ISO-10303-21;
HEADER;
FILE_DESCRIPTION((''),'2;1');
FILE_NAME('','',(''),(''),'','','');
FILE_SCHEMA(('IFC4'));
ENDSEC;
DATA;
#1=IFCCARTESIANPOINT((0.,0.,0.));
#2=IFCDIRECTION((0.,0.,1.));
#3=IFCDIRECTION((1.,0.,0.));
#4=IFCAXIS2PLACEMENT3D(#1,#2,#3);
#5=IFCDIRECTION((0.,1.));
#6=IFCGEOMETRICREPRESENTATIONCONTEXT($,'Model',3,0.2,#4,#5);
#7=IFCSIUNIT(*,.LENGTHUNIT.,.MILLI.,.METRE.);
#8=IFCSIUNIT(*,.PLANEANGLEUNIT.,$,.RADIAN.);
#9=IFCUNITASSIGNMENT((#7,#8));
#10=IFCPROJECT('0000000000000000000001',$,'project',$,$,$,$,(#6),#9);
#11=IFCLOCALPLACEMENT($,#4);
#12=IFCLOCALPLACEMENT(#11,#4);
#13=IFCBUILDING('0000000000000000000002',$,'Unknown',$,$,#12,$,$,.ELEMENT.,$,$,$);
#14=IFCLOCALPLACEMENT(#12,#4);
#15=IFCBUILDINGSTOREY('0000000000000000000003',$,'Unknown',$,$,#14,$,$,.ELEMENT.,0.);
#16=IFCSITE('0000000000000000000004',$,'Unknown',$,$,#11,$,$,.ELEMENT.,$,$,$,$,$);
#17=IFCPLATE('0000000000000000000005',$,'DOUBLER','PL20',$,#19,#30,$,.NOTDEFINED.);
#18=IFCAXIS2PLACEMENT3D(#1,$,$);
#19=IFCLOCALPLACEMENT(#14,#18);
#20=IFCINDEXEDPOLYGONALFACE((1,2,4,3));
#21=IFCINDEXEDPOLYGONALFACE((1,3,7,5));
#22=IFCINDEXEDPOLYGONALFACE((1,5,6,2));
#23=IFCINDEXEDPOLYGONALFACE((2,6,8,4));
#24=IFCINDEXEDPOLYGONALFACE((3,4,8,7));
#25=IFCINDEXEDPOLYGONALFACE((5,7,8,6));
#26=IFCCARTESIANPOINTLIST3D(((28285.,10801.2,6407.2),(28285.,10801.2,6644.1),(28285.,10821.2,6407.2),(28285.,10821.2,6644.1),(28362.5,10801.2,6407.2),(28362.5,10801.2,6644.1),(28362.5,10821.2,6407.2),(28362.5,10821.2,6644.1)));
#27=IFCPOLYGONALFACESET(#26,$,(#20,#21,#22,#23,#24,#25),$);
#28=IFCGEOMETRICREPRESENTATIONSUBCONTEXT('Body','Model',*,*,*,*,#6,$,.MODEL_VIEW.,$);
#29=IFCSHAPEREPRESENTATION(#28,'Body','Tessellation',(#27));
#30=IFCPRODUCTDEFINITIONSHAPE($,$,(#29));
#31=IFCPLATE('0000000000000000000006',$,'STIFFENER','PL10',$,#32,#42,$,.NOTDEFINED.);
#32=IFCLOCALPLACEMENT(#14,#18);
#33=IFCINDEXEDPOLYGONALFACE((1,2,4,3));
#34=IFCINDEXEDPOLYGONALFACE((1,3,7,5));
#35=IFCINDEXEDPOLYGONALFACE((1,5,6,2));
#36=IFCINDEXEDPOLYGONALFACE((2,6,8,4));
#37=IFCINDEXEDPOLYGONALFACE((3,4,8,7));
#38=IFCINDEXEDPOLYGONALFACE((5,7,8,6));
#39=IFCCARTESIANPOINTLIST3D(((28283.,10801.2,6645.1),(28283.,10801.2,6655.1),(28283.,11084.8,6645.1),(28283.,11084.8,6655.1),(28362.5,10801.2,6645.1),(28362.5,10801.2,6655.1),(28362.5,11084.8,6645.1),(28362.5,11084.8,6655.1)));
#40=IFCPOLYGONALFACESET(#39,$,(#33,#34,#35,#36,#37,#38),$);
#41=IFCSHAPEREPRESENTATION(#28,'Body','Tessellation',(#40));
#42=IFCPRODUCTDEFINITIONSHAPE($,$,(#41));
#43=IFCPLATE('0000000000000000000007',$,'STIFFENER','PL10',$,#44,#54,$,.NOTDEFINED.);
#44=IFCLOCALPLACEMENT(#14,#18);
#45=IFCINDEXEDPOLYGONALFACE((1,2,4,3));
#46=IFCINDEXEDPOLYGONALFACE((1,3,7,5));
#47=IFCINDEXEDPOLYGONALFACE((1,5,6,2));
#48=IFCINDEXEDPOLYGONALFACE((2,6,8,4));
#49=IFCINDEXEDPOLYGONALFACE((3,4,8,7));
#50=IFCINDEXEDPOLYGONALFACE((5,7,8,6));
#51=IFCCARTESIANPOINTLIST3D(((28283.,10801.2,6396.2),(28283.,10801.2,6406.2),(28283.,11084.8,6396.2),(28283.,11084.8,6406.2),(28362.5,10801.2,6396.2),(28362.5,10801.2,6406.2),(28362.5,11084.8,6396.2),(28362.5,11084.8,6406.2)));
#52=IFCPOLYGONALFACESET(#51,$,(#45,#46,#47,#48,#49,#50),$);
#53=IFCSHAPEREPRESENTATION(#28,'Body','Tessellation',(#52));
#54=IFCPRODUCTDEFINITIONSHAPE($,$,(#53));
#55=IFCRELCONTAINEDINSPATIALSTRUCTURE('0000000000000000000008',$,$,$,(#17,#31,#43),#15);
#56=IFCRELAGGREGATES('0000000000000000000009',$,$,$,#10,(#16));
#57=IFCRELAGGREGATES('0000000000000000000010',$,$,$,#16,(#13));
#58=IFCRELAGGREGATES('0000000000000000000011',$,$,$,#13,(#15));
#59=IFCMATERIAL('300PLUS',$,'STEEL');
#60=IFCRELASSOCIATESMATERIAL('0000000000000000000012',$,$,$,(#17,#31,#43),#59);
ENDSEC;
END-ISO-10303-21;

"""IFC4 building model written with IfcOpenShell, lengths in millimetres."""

from ifc_helpers import new_model, si_unit, direction, frame, origin_with_axes, place, context, subcontext, project, spatial, line, indexed_curve, outline, extrude, material, element, save


model = new_model("IFC4")

# Units and contexts
model_context = context("Model", 3, precision=0.2, world=origin_with_axes(), true_north=direction((0.0, 1.0)))
body_context = subcontext(model_context, "Body", "Model", "MODEL_VIEW")
ifc_project = project(units=[si_unit("LENGTHUNIT", "METRE", prefix="MILLI"), si_unit("PLANEANGLEUNIT", "RADIAN")], contexts=[model_context])

# Site, building, storey
site_placement = place(None, origin_with_axes())
site = spatial("IfcSite", under=ifc_project, at=site_placement, Name="Unknown", CompositionType="ELEMENT")
building_placement = place(site_placement, origin_with_axes())
building = spatial("IfcBuilding", under=site, at=building_placement, Name="Unknown", CompositionType="ELEMENT")
storey_placement = place(building_placement, origin_with_axes())
storey = spatial("IfcBuildingStorey", under=building, at=storey_placement, Name="Unknown", CompositionType="ELEMENT", Elevation=0.0)

# Shared definitions
ifc_material_1 = material(Name="300PLUS", Category="STEEL")

# Plates
plate_1_placement = place(storey_placement, frame((28285.0, 10811.2, 6407.2), z_axis=(0.0, -1.0, 0.0), x_axis=(1.0, 0.0, 0.0)))
element("IfcPlate", 1, at=plate_1_placement, inside=storey, material=ifc_material_1, Name="DOUBLER", Description="PL20", PredefinedType="NOTDEFINED", context=body_context, shape_type="SolidModel", body=[
    extrude(outline(indexed_curve([(0.0, 0.0), (77.5, 0.0), (77.5, 236.9), (0.0, 236.9)], segments=[line(1, 2, 3, 4, 1)])), frame((0.0, 0.0, 10.0), z_axis=(0.0, 0.0, 1.0), x_axis=(1.0, 0.0, 0.0)), (0.0, 0.0, -1.0), 20.0),
])
for number, where, z_axis, x_axis, name in (
    (2, (28283.0, 10801.2, 6650.1), (0.0, 0.0, 1.0), (1.0, 0.0, 0.0), "STIFFENER"),
    (3, (28283.0, 10801.2, 6401.2), (0.0, 0.0, 1.0), (1.0, 0.0, 0.0), "STIFFENER"),
):
    element("IfcPlate", number, at=place(storey_placement, frame(where, z_axis=z_axis, x_axis=x_axis)), inside=storey, material=ifc_material_1, Name=name, Description="PL10", PredefinedType="NOTDEFINED", context=body_context, shape_type="SolidModel", body=[
        extrude(outline(indexed_curve([(0.0, 0.0), (79.5, 0.0), (79.5, 283.6), (0.0, 283.6)], segments=[line(1, 2, 3, 4, 1)])), frame((0.0, 0.0, 5.0), z_axis=(0.0, 0.0, 1.0), x_axis=(1.0, 0.0, 0.0)), (0.0, 0.0, -1.0), 10.0),
    ])

save(model, "model.ifc")
